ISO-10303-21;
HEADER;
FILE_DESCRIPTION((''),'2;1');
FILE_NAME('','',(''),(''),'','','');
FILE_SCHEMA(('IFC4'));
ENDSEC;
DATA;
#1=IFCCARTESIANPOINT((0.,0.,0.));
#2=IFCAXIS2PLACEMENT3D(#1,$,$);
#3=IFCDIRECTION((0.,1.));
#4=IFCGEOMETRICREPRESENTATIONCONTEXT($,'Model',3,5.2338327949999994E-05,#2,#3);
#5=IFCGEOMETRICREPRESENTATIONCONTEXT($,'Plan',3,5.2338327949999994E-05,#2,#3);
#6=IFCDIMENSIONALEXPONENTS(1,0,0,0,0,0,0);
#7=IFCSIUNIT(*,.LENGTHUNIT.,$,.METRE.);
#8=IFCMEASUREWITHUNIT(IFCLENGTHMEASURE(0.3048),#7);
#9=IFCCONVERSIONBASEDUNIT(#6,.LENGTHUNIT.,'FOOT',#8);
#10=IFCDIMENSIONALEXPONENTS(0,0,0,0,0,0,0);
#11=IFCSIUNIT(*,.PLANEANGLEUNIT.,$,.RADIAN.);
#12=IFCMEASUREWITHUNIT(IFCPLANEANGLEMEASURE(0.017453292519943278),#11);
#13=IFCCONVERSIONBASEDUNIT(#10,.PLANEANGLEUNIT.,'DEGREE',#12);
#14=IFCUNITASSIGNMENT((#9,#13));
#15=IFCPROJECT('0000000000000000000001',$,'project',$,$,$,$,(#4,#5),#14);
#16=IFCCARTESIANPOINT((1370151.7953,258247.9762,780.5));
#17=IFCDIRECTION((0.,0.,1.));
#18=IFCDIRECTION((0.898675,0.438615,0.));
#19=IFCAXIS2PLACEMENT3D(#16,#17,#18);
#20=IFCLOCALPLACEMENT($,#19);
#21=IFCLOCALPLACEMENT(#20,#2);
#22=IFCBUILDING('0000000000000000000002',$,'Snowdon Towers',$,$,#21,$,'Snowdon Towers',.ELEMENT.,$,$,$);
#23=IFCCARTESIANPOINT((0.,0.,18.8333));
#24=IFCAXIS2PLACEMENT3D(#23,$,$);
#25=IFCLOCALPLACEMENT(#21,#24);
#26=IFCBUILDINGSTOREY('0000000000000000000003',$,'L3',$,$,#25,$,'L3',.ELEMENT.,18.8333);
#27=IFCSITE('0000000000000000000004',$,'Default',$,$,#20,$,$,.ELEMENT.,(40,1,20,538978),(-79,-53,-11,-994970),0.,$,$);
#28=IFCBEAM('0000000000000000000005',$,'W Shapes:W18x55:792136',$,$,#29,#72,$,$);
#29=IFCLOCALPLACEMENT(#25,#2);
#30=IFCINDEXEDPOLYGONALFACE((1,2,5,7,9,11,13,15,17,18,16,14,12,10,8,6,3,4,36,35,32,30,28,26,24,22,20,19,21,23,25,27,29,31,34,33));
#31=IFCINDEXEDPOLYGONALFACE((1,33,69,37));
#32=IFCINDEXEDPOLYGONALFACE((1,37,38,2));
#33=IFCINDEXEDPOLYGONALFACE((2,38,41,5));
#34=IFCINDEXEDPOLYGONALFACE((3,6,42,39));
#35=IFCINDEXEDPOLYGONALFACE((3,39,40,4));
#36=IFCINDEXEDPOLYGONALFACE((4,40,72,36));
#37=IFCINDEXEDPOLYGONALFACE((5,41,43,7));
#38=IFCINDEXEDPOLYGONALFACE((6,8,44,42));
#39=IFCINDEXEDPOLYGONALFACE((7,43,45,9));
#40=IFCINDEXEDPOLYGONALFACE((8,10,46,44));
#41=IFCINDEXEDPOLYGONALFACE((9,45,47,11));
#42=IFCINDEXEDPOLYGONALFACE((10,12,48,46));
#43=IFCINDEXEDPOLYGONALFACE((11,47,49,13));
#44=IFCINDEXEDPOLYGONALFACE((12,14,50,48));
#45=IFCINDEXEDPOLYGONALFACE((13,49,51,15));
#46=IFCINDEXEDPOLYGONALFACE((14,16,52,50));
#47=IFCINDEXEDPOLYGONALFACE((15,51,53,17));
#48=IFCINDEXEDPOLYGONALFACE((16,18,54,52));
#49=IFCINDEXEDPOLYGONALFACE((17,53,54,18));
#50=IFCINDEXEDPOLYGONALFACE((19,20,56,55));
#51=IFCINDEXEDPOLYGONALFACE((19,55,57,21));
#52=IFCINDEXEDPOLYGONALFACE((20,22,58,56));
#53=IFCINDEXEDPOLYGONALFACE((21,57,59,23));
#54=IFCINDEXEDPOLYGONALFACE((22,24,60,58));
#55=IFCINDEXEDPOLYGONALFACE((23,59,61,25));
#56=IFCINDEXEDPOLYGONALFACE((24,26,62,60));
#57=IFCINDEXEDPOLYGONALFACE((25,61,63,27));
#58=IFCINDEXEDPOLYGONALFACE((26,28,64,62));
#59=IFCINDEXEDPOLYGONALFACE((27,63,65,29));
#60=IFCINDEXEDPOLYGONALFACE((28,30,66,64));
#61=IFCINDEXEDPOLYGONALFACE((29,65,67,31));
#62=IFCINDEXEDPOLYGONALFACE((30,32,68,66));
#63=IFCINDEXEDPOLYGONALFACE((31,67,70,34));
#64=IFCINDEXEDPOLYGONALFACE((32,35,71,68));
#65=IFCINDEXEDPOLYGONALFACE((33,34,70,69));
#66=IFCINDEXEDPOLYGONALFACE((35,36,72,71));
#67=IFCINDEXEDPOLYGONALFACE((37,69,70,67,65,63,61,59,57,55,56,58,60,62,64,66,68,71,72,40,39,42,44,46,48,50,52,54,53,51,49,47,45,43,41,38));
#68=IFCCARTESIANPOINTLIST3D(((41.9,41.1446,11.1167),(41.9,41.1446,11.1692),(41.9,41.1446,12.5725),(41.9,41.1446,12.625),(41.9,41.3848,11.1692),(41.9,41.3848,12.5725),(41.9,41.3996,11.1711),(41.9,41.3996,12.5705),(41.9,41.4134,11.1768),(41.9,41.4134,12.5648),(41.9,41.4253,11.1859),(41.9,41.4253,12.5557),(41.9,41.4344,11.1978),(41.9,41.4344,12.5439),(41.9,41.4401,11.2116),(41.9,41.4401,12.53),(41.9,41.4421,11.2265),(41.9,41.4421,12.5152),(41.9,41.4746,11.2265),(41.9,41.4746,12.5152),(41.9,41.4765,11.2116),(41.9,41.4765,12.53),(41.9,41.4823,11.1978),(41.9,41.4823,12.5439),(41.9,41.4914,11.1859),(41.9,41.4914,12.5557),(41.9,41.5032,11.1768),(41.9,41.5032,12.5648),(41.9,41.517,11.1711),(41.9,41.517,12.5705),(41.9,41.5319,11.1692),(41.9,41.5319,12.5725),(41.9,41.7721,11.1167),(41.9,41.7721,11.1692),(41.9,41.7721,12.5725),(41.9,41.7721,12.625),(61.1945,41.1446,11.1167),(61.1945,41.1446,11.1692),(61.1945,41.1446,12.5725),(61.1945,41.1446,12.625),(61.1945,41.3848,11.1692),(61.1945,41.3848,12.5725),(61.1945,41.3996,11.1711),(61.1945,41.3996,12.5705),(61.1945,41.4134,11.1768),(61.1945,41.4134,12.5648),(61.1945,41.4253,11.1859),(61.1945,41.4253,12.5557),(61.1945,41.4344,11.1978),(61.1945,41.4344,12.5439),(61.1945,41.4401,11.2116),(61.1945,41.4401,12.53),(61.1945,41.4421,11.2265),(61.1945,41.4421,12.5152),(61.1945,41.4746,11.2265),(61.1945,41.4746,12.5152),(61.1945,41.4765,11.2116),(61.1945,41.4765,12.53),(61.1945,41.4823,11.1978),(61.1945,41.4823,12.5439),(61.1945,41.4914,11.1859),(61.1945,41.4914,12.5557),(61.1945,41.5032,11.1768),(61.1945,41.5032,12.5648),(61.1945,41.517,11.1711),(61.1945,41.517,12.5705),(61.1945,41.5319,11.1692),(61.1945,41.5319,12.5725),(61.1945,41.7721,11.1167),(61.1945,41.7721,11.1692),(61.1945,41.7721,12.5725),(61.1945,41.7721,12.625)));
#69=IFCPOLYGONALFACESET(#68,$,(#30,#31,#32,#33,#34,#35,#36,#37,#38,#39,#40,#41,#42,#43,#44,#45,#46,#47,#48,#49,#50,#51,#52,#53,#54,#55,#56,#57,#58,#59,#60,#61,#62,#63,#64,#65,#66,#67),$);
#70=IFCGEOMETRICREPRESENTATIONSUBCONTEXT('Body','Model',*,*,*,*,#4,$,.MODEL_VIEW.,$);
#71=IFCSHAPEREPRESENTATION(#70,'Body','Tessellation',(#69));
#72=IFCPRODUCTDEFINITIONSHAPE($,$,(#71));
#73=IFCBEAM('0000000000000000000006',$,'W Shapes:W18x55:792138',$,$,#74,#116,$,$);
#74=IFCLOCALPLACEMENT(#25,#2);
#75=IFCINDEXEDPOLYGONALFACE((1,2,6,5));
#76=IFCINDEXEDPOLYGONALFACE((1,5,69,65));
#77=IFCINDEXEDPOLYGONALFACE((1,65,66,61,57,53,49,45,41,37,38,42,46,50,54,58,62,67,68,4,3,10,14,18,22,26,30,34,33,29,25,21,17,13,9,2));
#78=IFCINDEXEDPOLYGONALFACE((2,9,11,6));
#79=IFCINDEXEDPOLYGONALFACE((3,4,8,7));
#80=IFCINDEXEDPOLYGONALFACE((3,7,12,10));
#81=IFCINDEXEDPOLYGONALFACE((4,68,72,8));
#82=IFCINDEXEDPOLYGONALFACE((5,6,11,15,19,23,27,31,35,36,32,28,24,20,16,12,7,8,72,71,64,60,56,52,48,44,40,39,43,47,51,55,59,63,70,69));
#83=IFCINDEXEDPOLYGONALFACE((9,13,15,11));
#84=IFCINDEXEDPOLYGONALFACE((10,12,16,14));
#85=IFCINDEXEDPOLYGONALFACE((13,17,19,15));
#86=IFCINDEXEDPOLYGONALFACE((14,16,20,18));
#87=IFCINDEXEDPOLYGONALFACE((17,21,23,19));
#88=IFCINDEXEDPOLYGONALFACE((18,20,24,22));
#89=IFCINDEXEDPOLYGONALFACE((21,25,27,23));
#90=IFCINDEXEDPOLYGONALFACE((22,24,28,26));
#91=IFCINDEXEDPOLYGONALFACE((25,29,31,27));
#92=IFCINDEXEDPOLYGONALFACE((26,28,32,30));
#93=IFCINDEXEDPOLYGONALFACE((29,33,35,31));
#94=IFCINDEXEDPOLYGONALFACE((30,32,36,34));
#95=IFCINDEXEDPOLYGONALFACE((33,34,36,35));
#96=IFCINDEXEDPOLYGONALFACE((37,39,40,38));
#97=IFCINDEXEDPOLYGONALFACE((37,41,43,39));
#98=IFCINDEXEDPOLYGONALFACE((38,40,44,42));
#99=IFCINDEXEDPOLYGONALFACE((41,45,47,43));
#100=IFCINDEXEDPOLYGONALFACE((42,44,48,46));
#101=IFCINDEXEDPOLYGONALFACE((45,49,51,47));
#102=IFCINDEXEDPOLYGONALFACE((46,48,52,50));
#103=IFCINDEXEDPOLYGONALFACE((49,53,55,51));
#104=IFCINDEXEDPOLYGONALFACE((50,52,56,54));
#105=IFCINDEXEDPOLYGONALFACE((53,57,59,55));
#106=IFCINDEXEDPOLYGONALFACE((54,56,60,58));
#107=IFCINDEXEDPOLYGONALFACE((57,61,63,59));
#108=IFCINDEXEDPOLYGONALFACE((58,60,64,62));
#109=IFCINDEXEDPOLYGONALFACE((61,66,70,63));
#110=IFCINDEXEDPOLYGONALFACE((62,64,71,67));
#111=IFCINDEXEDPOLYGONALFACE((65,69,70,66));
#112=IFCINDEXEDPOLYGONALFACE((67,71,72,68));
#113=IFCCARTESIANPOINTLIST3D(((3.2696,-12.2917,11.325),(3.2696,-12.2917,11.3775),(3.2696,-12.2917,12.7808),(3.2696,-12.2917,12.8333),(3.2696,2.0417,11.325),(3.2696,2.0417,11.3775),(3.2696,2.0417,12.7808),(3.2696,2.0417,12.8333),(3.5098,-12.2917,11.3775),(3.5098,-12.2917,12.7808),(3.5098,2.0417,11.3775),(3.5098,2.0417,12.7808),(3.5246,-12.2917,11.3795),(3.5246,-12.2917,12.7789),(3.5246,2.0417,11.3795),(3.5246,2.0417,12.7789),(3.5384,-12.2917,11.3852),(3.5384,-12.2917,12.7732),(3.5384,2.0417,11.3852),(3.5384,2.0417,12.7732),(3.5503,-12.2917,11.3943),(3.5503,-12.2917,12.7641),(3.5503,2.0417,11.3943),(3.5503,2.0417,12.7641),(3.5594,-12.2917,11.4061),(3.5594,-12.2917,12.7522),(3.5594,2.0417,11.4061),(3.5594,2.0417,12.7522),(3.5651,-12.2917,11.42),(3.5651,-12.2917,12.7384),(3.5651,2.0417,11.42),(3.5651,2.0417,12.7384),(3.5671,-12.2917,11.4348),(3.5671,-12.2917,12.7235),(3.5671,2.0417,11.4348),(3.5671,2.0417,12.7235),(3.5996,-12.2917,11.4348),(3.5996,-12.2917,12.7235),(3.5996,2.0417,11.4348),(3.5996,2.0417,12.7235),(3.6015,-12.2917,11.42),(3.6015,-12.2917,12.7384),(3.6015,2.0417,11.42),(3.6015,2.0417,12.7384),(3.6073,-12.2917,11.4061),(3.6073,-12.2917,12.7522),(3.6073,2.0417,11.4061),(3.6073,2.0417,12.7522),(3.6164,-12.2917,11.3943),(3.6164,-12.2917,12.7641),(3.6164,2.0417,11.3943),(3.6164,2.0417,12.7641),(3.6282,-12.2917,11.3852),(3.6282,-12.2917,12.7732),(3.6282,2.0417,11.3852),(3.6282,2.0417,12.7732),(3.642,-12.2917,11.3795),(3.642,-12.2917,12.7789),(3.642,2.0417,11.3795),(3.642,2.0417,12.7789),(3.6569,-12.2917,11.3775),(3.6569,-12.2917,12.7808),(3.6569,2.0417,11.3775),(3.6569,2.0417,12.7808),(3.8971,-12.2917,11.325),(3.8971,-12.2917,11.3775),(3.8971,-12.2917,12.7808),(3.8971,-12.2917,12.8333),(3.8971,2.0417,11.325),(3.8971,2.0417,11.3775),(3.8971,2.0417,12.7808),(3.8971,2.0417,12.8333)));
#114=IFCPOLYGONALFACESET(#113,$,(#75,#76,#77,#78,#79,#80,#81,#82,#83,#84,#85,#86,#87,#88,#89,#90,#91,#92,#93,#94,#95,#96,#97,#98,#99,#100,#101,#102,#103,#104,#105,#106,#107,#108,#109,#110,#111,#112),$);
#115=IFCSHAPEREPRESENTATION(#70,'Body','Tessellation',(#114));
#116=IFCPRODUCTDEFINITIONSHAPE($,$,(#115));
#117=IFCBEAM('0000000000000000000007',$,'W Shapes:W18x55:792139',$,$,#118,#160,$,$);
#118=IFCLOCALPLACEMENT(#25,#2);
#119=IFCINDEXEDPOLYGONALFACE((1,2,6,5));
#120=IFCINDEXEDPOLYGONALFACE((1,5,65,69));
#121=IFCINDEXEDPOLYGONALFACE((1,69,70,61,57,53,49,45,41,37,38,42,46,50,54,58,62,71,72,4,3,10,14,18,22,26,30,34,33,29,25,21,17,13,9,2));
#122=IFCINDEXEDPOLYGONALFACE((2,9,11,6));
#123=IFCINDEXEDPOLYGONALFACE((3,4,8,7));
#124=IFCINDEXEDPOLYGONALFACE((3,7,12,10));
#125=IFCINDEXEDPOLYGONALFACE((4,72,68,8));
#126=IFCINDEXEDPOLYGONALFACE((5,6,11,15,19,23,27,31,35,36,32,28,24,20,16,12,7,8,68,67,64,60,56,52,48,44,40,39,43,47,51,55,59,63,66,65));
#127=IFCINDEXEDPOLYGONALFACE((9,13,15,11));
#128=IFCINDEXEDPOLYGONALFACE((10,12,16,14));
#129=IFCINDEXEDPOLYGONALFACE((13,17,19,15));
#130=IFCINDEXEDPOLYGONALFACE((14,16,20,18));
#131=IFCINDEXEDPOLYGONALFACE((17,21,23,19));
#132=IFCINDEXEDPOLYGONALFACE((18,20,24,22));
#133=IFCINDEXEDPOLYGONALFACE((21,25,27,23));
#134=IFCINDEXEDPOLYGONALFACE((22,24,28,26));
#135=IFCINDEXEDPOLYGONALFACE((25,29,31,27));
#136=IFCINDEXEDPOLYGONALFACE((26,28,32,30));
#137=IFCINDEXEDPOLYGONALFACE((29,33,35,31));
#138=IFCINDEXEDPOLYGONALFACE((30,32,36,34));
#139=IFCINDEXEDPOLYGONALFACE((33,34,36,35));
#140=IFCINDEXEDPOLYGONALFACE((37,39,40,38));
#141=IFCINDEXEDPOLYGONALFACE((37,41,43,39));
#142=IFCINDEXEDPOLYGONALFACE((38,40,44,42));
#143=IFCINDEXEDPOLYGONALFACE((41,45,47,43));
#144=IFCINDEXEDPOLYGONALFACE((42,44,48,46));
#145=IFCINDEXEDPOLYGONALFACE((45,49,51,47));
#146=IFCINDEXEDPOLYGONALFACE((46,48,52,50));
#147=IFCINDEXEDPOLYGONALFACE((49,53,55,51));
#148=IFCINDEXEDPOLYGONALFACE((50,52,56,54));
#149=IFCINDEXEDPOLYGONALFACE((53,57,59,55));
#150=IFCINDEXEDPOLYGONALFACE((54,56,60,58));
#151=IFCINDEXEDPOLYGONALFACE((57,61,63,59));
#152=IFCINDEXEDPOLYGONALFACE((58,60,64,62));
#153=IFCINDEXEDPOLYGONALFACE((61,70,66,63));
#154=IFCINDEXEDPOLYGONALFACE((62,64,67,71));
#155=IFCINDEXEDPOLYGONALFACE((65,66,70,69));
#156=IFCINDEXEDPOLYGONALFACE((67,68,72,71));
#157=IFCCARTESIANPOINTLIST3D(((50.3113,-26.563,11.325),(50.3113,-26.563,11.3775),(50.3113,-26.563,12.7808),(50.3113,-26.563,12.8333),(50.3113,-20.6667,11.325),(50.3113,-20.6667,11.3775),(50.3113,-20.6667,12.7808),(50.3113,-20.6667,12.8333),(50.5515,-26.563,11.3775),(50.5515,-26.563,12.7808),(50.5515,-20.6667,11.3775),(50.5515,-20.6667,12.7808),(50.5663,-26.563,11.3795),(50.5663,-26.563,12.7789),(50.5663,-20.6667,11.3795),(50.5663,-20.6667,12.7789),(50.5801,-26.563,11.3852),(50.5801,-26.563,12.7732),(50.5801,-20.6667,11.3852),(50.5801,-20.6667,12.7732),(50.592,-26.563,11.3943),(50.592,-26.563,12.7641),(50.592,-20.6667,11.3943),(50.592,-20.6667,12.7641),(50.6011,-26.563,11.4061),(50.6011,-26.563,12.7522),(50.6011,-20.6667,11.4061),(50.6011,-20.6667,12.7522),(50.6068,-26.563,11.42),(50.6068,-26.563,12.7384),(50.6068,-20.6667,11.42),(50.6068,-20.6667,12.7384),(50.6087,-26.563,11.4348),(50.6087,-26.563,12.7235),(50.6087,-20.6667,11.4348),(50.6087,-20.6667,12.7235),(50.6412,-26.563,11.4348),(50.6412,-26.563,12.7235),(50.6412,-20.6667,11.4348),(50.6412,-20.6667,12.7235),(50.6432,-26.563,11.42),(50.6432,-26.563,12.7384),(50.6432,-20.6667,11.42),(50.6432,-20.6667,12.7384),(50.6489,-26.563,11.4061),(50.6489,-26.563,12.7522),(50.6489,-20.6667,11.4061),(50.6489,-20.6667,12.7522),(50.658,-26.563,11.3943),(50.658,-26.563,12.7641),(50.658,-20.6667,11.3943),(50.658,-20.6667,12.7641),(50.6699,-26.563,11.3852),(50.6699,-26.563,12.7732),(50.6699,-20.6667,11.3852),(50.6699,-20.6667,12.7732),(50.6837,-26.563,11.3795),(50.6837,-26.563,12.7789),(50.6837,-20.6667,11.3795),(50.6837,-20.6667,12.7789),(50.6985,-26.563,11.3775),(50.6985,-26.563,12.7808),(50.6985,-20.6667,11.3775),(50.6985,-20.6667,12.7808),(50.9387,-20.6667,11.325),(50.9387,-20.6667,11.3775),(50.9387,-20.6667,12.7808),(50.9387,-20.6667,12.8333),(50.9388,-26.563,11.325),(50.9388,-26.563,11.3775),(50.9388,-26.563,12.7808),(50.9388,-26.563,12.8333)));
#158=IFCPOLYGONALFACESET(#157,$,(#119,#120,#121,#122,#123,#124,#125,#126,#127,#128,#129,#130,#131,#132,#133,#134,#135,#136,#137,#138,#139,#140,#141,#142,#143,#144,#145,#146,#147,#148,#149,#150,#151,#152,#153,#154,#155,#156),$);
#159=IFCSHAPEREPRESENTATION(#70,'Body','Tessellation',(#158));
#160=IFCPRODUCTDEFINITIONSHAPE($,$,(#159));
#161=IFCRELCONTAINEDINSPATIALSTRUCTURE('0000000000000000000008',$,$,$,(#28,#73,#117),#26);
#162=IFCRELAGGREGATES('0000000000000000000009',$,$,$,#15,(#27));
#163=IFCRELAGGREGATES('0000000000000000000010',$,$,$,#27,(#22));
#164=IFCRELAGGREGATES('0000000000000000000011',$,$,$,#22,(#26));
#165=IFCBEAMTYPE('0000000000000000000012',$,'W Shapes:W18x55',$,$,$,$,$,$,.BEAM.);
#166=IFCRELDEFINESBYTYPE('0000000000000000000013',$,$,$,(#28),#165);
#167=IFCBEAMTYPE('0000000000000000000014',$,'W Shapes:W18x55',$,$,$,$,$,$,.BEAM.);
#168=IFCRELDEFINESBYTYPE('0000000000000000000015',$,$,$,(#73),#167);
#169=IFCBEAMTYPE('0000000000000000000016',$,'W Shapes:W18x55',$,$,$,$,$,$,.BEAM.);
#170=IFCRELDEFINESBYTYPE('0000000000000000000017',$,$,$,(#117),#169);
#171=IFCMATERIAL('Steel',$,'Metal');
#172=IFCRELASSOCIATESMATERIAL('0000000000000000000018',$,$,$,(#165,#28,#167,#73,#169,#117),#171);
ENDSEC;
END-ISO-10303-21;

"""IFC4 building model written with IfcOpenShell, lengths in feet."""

from ifc_helpers import new_model, entity, si_unit, converted_unit, direction, frame, origin, place, context, subcontext, project, spatial, line, arc, indexed_curve, outline, extrude, source, transform, mapped, material, type_object, type_shapes, element, save


model = new_model("IFC4")

# Units and contexts
model_context = context("Model", 3, precision=5.2338327949999994e-05, world=origin(), true_north=direction((0.0, 1.0)))
plan_context = context("Plan", 3, precision=5.2338327949999994e-05, world=origin(), true_north=direction((0.0, 1.0)))
body_context = subcontext(model_context, "Body", "Model", "MODEL_VIEW")
ifc_project = project(units=[converted_unit("LENGTHUNIT", "FOOT", entity("IfcLengthMeasure", 0.3048), si_unit("LENGTHUNIT", "METRE"), dimensions=[1, 0, 0, 0, 0, 0, 0]), converted_unit("PLANEANGLEUNIT", "DEGREE", entity("IfcPlaneAngleMeasure", 0.017453292519943278), si_unit("PLANEANGLEUNIT", "RADIAN"), dimensions=[0, 0, 0, 0, 0, 0, 0])], contexts=[model_context, plan_context])

# Site, building, storey
site_placement = place(None, frame((1370151.7953, 258247.9762, 780.5), z_axis=(0.0, 0.0, 1.0), x_axis=(0.898675, 0.438615, 0.0)))
site = spatial("IfcSite", under=ifc_project, at=site_placement, Name="Default", CompositionType="ELEMENT", RefLatitude=(40, 1, 20, 538978), RefLongitude=(-79, -53, -11, -994970), RefElevation=0.0)
building_placement = place(site_placement, origin())
building = spatial("IfcBuilding", under=site, at=building_placement, Name="Snowdon Towers", LongName="Snowdon Towers", CompositionType="ELEMENT")
storey_placement = place(building_placement, frame((0.0, 0.0, 18.8333)))
storey = spatial("IfcBuildingStorey", under=building, at=storey_placement, Name="L3", LongName="L3", CompositionType="ELEMENT", Elevation=18.8333)

# Beams
ifc_material_1 = material(Name="Steel", Category="Metal")
beam_type_1 = type_object("IfcBeamType", Name="W Shapes:W18x55", PredefinedType="BEAM", material=ifc_material_1)
shared_shape_1 = source(origin(), body_context, "Body", "SweptSolid", [
    extrude(outline(indexed_curve([(-0.7542, -0.3138), (-0.7017, -0.3138), (-0.7017, -0.0735), (-0.6849, -0.033), (-0.6444, -0.0162), (0.6444, -0.0162), (0.6849, -0.033), (0.7017, -0.0735), (0.7017, -0.3138), (0.7542, -0.3138), (0.7542, 0.3138), (0.7017, 0.3138), (0.7017, 0.0735), (0.6849, 0.033), (0.6444, 0.0163), (-0.6444, 0.0163), (-0.6849, 0.033), (-0.7017, 0.0735), (-0.7017, 0.3137), (-0.7542, 0.3137)], segments=[line(1, 2, 3), arc(3, 4, 5), line(5, 6), arc(6, 7, 8), line(8, 9, 10, 11, 12, 13), arc(13, 14, 15), line(15, 16), arc(16, 17, 18), line(18, 19, 20, 1)], self_intersect=False)), frame((-9.9242, 0.0, 0.0), z_axis=(1.0, 0.0, 0.0), x_axis=(0.0, 0.0, -1.0)), (0.0, 0.0, 1.0), 19.2945),
])
type_shapes(beam_type_1, [shared_shape_1])
beam_1_placement = place(storey_placement, frame((51.8242, 41.4583, 11.8708)))
element("IfcBeam", 1, at=beam_1_placement, inside=storey, type_object=beam_type_1, material=ifc_material_1, Name="W Shapes:W18x55:792136", context=body_context, shape_type="MappedRepresentation", body=[
    mapped(shared_shape_1, transform((0.0, 0.0, 0.0), scale=1.0)),
])
beam_type_2 = type_object("IfcBeamType", Name="W Shapes:W18x55", PredefinedType="BEAM", material=ifc_material_1)
shared_shape_2 = source(origin(), body_context, "Body", "SweptSolid", [
    extrude(outline(indexed_curve([(-0.7542, -0.3138), (-0.7017, -0.3138), (-0.7017, -0.0735), (-0.6849, -0.033), (-0.6444, -0.0162), (0.6444, -0.0162), (0.6849, -0.033), (0.7017, -0.0735), (0.7017, -0.3138), (0.7542, -0.3138), (0.7542, 0.3138), (0.7017, 0.3138), (0.7017, 0.0735), (0.6849, 0.033), (0.6444, 0.0163), (-0.6444, 0.0163), (-0.6849, 0.033), (-0.7017, 0.0735), (-0.7017, 0.3137), (-0.7542, 0.3137)], segments=[line(1, 2, 3), arc(3, 4, 5), line(5, 6), arc(6, 7, 8), line(8, 9, 10, 11, 12, 13), arc(13, 14, 15), line(15, 16), arc(16, 17, 18), line(18, 19, 20, 1)], self_intersect=False)), frame((-7.1458, 0.0, 0.0), z_axis=(1.0, 0.0, 0.0), x_axis=(0.0, 0.0, -1.0)), (0.0, 0.0, 1.0), 14.3333),
])
type_shapes(beam_type_2, [shared_shape_2])
beam_2_placement = place(storey_placement, frame((3.5833, -5.1042, 12.0792), z_axis=(0.0, 0.0, 1.0), x_axis=(0.0, -1.0, 0.0)))
element("IfcBeam", 2, at=beam_2_placement, inside=storey, type_object=beam_type_2, material=ifc_material_1, Name="W Shapes:W18x55:792138", context=body_context, shape_type="MappedRepresentation", body=[
    mapped(shared_shape_2, transform((0.0, 0.0, 0.0), scale=1.0)),
])
beam_type_3 = type_object("IfcBeamType", Name="W Shapes:W18x55", PredefinedType="BEAM", material=ifc_material_1)
shared_shape_3 = source(origin(), body_context, "Body", "SweptSolid", [
    extrude(outline(indexed_curve([(-0.7542, -0.3138), (-0.7017, -0.3138), (-0.7017, -0.0735), (-0.6849, -0.033), (-0.6444, -0.0162), (0.6444, -0.0162), (0.6849, -0.033), (0.7017, -0.0735), (0.7017, -0.3138), (0.7542, -0.3138), (0.7542, 0.3138), (0.7017, 0.3138), (0.7017, 0.0735), (0.6849, 0.033), (0.6444, 0.0163), (-0.6444, 0.0163), (-0.6849, 0.033), (-0.7017, 0.0735), (-0.7017, 0.3137), (-0.7542, 0.3137)], segments=[line(1, 2, 3), arc(3, 4, 5), line(5, 6), arc(6, 7, 8), line(8, 9, 10, 11, 12, 13), arc(13, 14, 15), line(15, 16), arc(16, 17, 18), line(18, 19, 20, 1)], self_intersect=False)), frame((-2.8655, 0.0, 0.0), z_axis=(1.0, 0.0, 0.0), x_axis=(0.0, 0.0, -1.0)), (0.0, 0.0, 1.0), 5.8964),
])
type_shapes(beam_type_3, [shared_shape_3])
beam_3_placement = place(storey_placement, frame((50.625, -23.5321, 12.0792), z_axis=(0.0, 0.0, 1.0), x_axis=(0.0, -1.0, 0.0)))
element("IfcBeam", 3, at=beam_3_placement, inside=storey, type_object=beam_type_3, material=ifc_material_1, Name="W Shapes:W18x55:792139", context=body_context, shape_type="MappedRepresentation", body=[
    mapped(shared_shape_3, transform((0.0, 0.0, 0.0), scale=1.0)),
])

save(model, "model.ifc")
